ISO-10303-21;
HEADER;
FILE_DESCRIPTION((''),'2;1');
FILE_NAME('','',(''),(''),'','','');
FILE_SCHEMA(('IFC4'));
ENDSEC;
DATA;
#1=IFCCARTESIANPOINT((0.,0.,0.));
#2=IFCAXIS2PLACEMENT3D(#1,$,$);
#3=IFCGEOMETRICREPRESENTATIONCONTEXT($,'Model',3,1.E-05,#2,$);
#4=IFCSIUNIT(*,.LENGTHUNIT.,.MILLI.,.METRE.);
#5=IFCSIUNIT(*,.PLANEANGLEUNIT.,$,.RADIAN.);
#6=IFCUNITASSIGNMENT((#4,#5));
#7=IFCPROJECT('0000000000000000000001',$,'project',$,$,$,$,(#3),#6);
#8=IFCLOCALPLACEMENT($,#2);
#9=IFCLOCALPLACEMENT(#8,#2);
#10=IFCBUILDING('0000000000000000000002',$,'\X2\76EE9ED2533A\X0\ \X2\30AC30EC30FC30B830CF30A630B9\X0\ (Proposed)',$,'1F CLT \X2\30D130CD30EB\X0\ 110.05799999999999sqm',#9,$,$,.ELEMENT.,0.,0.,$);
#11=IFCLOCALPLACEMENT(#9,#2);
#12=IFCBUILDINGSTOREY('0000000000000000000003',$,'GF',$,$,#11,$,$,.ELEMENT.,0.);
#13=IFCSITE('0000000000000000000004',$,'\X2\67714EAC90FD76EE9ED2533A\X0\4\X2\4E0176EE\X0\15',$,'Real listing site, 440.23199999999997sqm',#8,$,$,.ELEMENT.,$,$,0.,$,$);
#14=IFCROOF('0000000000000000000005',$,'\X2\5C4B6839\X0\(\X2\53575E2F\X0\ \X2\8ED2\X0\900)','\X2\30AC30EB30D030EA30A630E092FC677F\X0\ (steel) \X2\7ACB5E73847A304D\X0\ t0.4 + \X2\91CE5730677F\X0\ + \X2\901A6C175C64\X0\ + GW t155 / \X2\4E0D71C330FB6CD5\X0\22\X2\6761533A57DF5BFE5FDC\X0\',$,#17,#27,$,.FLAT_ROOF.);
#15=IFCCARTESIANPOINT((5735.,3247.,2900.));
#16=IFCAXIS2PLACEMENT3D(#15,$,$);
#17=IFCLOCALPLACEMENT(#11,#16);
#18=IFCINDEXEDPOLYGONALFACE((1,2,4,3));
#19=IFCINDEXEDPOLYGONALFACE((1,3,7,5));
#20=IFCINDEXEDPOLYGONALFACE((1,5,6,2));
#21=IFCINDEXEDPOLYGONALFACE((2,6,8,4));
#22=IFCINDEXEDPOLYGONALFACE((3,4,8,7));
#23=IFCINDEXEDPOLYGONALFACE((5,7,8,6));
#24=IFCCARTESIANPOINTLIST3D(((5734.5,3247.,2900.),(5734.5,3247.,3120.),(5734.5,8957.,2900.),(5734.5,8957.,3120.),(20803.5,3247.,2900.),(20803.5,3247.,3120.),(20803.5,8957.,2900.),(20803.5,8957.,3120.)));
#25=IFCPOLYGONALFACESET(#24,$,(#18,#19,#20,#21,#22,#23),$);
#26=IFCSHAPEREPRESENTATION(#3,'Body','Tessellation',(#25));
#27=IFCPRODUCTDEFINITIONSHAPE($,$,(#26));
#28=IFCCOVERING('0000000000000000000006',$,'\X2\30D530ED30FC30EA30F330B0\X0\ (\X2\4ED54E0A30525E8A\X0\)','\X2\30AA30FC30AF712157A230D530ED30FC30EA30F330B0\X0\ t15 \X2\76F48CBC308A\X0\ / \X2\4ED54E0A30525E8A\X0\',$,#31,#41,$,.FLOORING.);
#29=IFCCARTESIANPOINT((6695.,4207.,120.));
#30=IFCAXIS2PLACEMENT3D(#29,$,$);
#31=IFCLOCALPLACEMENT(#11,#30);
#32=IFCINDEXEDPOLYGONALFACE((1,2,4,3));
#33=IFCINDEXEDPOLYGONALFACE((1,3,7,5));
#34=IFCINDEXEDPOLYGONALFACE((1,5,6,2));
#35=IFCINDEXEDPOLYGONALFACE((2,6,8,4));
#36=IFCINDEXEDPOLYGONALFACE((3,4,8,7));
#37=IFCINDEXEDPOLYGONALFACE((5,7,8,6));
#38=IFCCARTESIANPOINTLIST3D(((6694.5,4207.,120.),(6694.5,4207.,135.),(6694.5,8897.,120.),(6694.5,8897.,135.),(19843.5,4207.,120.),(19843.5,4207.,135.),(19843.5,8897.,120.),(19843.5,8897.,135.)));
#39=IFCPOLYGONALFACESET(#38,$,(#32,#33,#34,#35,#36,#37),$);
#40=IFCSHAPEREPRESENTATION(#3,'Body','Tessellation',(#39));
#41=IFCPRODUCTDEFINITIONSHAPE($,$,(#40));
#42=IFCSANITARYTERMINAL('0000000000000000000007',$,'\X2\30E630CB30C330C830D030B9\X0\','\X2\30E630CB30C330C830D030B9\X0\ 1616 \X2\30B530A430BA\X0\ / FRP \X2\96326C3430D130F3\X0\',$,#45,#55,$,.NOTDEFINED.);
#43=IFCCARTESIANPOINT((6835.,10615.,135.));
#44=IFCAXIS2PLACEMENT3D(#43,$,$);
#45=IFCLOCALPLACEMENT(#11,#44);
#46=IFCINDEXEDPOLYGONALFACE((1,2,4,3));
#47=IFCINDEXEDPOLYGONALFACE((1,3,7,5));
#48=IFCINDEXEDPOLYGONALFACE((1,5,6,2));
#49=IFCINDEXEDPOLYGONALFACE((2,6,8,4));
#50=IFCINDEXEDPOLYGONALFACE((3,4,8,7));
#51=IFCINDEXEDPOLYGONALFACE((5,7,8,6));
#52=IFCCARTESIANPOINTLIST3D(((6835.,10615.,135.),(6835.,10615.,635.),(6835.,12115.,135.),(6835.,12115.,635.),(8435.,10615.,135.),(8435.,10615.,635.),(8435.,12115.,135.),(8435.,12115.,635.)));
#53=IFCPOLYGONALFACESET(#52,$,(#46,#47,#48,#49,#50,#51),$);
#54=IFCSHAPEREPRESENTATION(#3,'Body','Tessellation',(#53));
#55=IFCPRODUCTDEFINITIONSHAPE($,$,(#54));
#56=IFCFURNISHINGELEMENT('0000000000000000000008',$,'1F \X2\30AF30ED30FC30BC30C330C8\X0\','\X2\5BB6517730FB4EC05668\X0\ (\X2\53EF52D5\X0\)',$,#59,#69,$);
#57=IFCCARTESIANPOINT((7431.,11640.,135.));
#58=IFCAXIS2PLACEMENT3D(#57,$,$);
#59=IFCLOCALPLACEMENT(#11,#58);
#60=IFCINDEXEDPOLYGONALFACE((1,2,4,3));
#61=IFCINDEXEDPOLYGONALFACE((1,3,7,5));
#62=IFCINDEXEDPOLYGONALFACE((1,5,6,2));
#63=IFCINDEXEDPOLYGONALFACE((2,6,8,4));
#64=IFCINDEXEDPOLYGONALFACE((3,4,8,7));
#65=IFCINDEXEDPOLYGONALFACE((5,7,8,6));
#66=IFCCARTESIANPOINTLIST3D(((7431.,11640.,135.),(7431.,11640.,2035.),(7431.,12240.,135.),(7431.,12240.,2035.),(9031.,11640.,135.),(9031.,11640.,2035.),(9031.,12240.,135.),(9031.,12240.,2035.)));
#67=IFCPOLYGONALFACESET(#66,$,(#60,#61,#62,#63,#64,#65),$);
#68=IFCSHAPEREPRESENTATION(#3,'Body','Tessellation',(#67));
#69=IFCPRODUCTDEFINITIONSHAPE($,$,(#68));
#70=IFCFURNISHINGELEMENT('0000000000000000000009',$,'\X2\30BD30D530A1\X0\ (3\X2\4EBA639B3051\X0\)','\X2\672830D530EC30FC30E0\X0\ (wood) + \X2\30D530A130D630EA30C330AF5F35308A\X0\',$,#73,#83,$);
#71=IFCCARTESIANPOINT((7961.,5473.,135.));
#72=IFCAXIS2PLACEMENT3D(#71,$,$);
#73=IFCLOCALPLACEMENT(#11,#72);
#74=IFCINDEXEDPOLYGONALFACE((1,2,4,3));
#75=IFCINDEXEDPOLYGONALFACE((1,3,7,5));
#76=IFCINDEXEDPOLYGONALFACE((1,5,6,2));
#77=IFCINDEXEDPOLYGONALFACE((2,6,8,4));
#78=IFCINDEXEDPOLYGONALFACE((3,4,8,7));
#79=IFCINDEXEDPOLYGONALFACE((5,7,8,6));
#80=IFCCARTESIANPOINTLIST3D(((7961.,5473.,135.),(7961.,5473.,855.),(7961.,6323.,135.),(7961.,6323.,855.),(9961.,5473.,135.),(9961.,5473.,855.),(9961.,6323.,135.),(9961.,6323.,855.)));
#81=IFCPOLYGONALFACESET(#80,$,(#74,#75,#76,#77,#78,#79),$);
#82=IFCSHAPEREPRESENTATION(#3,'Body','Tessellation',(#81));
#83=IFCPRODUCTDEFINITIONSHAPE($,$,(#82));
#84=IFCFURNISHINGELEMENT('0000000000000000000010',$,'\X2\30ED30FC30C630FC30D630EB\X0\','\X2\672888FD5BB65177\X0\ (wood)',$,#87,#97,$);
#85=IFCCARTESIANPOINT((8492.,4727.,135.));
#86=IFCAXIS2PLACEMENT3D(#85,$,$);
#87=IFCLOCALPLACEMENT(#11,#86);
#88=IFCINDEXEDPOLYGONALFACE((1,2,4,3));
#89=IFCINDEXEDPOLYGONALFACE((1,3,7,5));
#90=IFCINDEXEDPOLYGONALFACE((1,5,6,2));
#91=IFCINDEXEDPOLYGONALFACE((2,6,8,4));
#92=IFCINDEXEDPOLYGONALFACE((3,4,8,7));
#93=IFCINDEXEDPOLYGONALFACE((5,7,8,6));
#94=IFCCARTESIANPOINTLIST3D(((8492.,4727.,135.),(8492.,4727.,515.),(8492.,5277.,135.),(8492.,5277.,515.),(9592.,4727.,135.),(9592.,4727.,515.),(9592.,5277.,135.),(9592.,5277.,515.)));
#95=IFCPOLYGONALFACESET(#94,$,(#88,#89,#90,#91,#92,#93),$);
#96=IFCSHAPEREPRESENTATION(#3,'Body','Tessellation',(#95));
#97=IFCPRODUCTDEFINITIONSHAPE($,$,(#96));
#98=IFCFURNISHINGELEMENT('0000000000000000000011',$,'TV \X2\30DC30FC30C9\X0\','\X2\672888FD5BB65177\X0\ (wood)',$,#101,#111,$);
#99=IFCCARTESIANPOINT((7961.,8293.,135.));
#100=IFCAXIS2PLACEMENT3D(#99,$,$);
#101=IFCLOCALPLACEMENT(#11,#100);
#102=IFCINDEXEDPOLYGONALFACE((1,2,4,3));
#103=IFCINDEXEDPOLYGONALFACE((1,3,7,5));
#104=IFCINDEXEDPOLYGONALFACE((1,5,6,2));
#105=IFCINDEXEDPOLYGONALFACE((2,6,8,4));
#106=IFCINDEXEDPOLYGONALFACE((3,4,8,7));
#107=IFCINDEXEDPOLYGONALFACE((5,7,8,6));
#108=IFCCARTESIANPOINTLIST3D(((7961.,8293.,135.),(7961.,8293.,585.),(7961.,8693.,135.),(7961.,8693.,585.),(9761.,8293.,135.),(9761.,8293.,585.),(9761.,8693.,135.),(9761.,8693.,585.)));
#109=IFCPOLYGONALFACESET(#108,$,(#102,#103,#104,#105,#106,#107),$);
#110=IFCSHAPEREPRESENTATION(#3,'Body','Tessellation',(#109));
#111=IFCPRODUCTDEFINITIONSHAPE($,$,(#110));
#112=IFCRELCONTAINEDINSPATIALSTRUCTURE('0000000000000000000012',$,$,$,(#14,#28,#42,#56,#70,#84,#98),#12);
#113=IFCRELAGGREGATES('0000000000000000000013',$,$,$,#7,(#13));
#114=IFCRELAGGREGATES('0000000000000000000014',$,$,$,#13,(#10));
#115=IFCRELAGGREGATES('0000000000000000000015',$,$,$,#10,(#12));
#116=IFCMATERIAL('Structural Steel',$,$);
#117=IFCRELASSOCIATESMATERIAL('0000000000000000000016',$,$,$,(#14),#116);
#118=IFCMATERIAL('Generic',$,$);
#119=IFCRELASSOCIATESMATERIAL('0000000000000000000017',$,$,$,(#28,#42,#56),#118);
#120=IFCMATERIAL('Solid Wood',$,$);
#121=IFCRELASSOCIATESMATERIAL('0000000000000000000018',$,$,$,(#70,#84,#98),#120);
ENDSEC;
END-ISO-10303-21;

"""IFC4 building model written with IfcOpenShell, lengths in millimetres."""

from ifc_helpers import new_model, si_unit, frame, frame_2d, origin, place, context, project, spatial, rectangle, extrude, material, element, save


model = new_model("IFC4")

# Units and contexts
model_context = context("Model", 3, precision=1e-05, world=origin())
ifc_project = project(units=[si_unit("LENGTHUNIT", "METRE", prefix="MILLI"), si_unit("PLANEANGLEUNIT", "RADIAN")], contexts=[model_context])

# Site, building, storey
site_placement = place(None, origin())
site = spatial("IfcSite", under=ifc_project, at=site_placement, Name="東京都目黒区4丁目15", ObjectType="Real listing site, 440.23199999999997sqm", CompositionType="ELEMENT", RefElevation=0.0)
building_placement = place(site_placement, origin())
building = spatial("IfcBuilding", under=site, at=building_placement, Name="目黒区 ガレージハウス (Proposed)", ObjectType="1F CLT パネル 110.05799999999999sqm", CompositionType="ELEMENT", ElevationOfRefHeight=0.0, ElevationOfTerrain=0.0)
storey_placement = place(building_placement, origin())
storey = spatial("IfcBuildingStorey", under=building, at=storey_placement, Name="GF", CompositionType="ELEMENT", Elevation=0.0)

# Shared definitions
ifc_material_1 = material(Name="Solid Wood")

# Roof
ifc_material_2 = material(Name="Structural Steel")
roof_1_placement = place(storey_placement, frame((5735.0, 3247.0, 2900.0)))
element("IfcRoof", 1, at=roof_1_placement, inside=storey, material=ifc_material_2, Name="屋根(南帯 軒900)", Description="ガルバリウム鋼板 (steel) 立平葺き t0.4 + 野地板 + 通気層 + GW t155 / 不燃・法22条区域対応", PredefinedType="FLAT_ROOF", context=model_context, shape_type="SweptSolid", body=[
    extrude(rectangle(XDim=15069.0, YDim=5710.0, at=frame_2d((7534.0, 2855.0))), frame((5735.0, 3247.0, 2900.0)), (0.0, 0.0, 1.0), 220.0),
])

# Covering
ifc_material_3 = material(Name="Generic")
covering_1_placement = place(storey_placement, frame((6695.0, 4207.0, 120.0)))
element("IfcCovering", 2, at=covering_1_placement, inside=storey, material=ifc_material_3, Name="フローリング (仕上げ床)", Description="オーク無垢フローリング t15 直貼り / 仕上げ床", PredefinedType="FLOORING", context=model_context, shape_type="SweptSolid", body=[
    extrude(rectangle(XDim=13149.0, YDim=4690.0, at=frame_2d((6574.0, 2345.0))), frame((6695.0, 4207.0, 120.0)), (0.0, 0.0, 1.0), 15.0),
])

# Sanitary terminal
sanitary_terminal_placement = place(storey_placement, frame((6835.0, 10615.0, 135.0)))
element("IfcSanitaryTerminal", 3, at=sanitary_terminal_placement, inside=storey, material=ifc_material_3, Name="ユニットバス", Description="ユニットバス 1616 サイズ / FRP 防水パン", PredefinedType="NOTDEFINED", context=model_context, shape_type="SweptSolid", body=[
    extrude(rectangle(XDim=1600.0, YDim=1500.0, at=frame_2d((800.0, 750.0))), frame((6835.0, 10615.0, 135.0)), (0.0, 0.0, 1.0), 500.0),
])

# Furnishing elements
furnishing_1_placement = place(storey_placement, frame((7431.0, 11640.0, 135.0)))
element("IfcFurnishingElement", 4, at=furnishing_1_placement, inside=storey, material=ifc_material_3, Name="1F クローゼット", Description="家具・什器 (可動)", context=model_context, shape_type="SweptSolid", body=[
    extrude(rectangle(XDim=1600.0, YDim=600.0, at=frame_2d((800.0, 300.0))), frame((7431.0, 11640.0, 135.0)), (0.0, 0.0, 1.0), 1900.0),
])
furnishing_2_placement = place(storey_placement, frame((7961.0, 5473.0, 135.0)))
element("IfcFurnishingElement", 5, at=furnishing_2_placement, inside=storey, material=ifc_material_1, Name="ソファ (3人掛け)", Description="木フレーム (wood) + ファブリック張り", context=model_context, shape_type="SweptSolid", body=[
    extrude(rectangle(XDim=2000.0, YDim=850.0, at=frame_2d((1000.0, 425.0))), frame((7961.0, 5473.0, 135.0)), (0.0, 0.0, 1.0), 720.0),
])
furnishing_3_placement = place(storey_placement, frame((8492.0, 4727.0, 135.0)))
element("IfcFurnishingElement", 6, at=furnishing_3_placement, inside=storey, material=ifc_material_1, Name="ローテーブル", Description="木製家具 (wood)", context=model_context, shape_type="SweptSolid", body=[
    extrude(rectangle(XDim=1100.0, YDim=550.0, at=frame_2d((550.0, 275.0))), frame((8492.0, 4727.0, 135.0)), (0.0, 0.0, 1.0), 380.0),
])
furnishing_4_placement = place(storey_placement, frame((7961.0, 8293.0, 135.0)))
element("IfcFurnishingElement", 7, at=furnishing_4_placement, inside=storey, material=ifc_material_1, Name="TV ボード", Description="木製家具 (wood)", context=model_context, shape_type="SweptSolid", body=[
    extrude(rectangle(XDim=1800.0, YDim=400.0, at=frame_2d((900.0, 200.0))), frame((7961.0, 8293.0, 135.0)), (0.0, 0.0, 1.0), 450.0),
])

save(model, "model.ifc")
